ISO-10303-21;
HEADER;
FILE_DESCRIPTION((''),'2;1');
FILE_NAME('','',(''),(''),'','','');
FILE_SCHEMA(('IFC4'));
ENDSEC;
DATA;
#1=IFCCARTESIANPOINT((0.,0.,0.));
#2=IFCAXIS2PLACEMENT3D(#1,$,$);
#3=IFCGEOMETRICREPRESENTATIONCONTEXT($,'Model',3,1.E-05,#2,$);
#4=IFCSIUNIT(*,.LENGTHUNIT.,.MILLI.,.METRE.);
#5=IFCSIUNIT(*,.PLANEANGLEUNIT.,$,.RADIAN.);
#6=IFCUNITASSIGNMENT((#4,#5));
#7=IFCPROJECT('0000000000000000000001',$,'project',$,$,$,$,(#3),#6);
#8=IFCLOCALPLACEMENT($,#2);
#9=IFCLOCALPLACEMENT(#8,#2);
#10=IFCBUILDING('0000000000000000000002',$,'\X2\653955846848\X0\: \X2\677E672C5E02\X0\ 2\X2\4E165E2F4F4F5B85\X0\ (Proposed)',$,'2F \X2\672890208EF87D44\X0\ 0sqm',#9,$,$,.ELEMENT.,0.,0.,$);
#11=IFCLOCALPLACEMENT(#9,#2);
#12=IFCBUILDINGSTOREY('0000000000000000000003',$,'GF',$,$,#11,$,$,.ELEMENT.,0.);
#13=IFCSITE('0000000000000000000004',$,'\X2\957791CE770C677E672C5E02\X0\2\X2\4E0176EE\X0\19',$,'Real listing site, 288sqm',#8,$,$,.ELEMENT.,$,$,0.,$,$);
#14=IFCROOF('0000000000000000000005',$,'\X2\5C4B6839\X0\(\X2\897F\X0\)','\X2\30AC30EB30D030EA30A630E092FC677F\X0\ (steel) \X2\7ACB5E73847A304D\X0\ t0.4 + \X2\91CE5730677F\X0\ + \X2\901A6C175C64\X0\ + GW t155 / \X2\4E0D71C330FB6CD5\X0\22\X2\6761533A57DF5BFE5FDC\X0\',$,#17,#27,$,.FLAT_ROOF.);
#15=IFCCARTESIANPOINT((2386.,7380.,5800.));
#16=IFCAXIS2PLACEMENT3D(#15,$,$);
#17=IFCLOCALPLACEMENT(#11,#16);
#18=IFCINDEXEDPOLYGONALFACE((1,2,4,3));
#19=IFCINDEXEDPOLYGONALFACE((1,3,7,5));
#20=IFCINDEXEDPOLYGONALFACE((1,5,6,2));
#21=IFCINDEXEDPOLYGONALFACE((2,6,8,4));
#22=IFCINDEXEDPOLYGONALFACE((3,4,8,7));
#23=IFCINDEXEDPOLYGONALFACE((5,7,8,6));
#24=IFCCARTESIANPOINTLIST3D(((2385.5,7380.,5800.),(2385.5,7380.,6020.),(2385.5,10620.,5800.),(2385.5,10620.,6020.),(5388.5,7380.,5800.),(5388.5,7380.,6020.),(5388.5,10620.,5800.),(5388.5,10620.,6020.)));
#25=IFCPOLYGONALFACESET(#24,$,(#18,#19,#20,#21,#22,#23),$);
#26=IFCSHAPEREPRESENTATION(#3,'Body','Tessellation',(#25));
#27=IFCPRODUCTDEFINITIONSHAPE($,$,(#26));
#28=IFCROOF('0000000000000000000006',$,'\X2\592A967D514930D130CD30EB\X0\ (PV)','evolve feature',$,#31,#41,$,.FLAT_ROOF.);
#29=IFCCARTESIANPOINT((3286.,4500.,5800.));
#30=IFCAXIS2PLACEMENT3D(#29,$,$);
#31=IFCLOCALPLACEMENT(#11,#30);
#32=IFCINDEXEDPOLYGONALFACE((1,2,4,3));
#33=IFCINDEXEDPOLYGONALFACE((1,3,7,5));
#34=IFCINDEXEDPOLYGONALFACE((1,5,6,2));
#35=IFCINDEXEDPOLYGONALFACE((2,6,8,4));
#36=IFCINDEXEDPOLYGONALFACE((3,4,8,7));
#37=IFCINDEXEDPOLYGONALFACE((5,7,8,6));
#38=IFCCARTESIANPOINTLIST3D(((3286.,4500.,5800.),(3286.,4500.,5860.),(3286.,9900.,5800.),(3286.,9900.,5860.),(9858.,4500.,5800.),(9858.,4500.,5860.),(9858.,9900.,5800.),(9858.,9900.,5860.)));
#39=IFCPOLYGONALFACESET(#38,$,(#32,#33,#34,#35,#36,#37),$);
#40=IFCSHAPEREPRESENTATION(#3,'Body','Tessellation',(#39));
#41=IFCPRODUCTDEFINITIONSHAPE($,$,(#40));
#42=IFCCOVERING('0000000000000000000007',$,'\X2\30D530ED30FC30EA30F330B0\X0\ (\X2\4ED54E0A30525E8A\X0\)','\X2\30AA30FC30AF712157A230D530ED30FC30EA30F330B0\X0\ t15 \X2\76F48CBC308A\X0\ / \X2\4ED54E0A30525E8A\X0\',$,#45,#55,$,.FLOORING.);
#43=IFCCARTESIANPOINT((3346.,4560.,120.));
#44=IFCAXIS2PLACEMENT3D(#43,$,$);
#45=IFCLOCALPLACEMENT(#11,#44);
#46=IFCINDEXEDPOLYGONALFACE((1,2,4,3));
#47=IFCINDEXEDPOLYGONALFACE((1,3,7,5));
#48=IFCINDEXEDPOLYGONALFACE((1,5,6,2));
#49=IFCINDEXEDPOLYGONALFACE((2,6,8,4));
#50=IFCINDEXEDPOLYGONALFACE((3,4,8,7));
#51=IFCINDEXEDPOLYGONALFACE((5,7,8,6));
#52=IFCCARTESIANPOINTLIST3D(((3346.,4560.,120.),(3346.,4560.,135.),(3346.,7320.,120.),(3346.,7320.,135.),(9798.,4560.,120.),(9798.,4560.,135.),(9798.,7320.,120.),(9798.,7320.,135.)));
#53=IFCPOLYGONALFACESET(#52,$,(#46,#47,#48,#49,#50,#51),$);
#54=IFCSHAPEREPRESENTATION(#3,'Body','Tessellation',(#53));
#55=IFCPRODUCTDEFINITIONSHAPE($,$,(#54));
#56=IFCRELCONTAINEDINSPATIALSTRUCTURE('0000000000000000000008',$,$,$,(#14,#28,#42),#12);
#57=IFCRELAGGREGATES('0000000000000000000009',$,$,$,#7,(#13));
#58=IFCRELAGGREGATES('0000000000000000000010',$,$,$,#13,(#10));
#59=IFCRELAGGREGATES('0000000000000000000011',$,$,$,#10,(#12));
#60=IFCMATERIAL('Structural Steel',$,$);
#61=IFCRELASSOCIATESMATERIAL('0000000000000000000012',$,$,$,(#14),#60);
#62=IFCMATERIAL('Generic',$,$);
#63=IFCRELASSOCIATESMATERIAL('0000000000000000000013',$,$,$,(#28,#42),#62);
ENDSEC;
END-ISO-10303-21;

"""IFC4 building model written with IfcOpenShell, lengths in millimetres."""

from ifc_helpers import new_model, si_unit, frame, frame_2d, origin, place, context, project, spatial, rectangle, extrude, material, element, save


model = new_model("IFC4")

# Units and contexts
model_context = context("Model", 3, precision=1e-05, world=origin())
ifc_project = project(units=[si_unit("LENGTHUNIT", "METRE", prefix="MILLI"), si_unit("PLANEANGLEUNIT", "RADIAN")], contexts=[model_context])

# Site, building, storey
site_placement = place(None, origin())
site = spatial("IfcSite", under=ifc_project, at=site_placement, Name="長野県松本市2丁目19", ObjectType="Real listing site, 288sqm", CompositionType="ELEMENT", RefElevation=0.0)
building_placement = place(site_placement, origin())
building = spatial("IfcBuilding", under=site, at=building_placement, Name="改善案: 松本市 2世帯住宅 (Proposed)", ObjectType="2F 木造軸組 0sqm", CompositionType="ELEMENT", ElevationOfRefHeight=0.0, ElevationOfTerrain=0.0)
storey_placement = place(building_placement, origin())
storey = spatial("IfcBuildingStorey", under=building, at=storey_placement, Name="GF", CompositionType="ELEMENT", Elevation=0.0)

# Shared definitions
ifc_material_1 = material(Name="Generic")

# Roofs
ifc_material_2 = material(Name="Structural Steel")
roof_1_placement = place(storey_placement, frame((2386.0, 7380.0, 5800.0)))
element("IfcRoof", 1, at=roof_1_placement, inside=storey, material=ifc_material_2, Name="屋根(西)", Description="ガルバリウム鋼板 (steel) 立平葺き t0.4 + 野地板 + 通気層 + GW t155 / 不燃・法22条区域対応", PredefinedType="FLAT_ROOF", context=model_context, shape_type="SweptSolid", body=[
    extrude(rectangle(XDim=3003.0, YDim=3240.0, at=frame_2d((1501.0, 1620.0))), frame((2386.0, 7380.0, 5800.0)), (0.0, 0.0, 1.0), 220.0),
])
roof_2_placement = place(storey_placement, frame((3286.0, 4500.0, 5800.0)))
element("IfcRoof", 2, at=roof_2_placement, inside=storey, material=ifc_material_1, Name="太陽光パネル (PV)", Description="evolve feature", PredefinedType="FLAT_ROOF", context=model_context, shape_type="SweptSolid", body=[
    extrude(rectangle(XDim=6572.0, YDim=5400.0, at=frame_2d((3286.0, 2700.0))), frame((3286.0, 4500.0, 5800.0)), (0.0, 0.0, 1.0), 60.0),
])

# Covering
covering_placement = place(storey_placement, frame((3346.0, 4560.0, 120.0)))
element("IfcCovering", 3, at=covering_placement, inside=storey, material=ifc_material_1, Name="フローリング (仕上げ床)", Description="オーク無垢フローリング t15 直貼り / 仕上げ床", PredefinedType="FLOORING", context=model_context, shape_type="SweptSolid", body=[
    extrude(rectangle(XDim=6452.0, YDim=2760.0, at=frame_2d((3226.0, 1380.0))), frame((3346.0, 4560.0, 120.0)), (0.0, 0.0, 1.0), 15.0),
])

save(model, "model.ifc")
